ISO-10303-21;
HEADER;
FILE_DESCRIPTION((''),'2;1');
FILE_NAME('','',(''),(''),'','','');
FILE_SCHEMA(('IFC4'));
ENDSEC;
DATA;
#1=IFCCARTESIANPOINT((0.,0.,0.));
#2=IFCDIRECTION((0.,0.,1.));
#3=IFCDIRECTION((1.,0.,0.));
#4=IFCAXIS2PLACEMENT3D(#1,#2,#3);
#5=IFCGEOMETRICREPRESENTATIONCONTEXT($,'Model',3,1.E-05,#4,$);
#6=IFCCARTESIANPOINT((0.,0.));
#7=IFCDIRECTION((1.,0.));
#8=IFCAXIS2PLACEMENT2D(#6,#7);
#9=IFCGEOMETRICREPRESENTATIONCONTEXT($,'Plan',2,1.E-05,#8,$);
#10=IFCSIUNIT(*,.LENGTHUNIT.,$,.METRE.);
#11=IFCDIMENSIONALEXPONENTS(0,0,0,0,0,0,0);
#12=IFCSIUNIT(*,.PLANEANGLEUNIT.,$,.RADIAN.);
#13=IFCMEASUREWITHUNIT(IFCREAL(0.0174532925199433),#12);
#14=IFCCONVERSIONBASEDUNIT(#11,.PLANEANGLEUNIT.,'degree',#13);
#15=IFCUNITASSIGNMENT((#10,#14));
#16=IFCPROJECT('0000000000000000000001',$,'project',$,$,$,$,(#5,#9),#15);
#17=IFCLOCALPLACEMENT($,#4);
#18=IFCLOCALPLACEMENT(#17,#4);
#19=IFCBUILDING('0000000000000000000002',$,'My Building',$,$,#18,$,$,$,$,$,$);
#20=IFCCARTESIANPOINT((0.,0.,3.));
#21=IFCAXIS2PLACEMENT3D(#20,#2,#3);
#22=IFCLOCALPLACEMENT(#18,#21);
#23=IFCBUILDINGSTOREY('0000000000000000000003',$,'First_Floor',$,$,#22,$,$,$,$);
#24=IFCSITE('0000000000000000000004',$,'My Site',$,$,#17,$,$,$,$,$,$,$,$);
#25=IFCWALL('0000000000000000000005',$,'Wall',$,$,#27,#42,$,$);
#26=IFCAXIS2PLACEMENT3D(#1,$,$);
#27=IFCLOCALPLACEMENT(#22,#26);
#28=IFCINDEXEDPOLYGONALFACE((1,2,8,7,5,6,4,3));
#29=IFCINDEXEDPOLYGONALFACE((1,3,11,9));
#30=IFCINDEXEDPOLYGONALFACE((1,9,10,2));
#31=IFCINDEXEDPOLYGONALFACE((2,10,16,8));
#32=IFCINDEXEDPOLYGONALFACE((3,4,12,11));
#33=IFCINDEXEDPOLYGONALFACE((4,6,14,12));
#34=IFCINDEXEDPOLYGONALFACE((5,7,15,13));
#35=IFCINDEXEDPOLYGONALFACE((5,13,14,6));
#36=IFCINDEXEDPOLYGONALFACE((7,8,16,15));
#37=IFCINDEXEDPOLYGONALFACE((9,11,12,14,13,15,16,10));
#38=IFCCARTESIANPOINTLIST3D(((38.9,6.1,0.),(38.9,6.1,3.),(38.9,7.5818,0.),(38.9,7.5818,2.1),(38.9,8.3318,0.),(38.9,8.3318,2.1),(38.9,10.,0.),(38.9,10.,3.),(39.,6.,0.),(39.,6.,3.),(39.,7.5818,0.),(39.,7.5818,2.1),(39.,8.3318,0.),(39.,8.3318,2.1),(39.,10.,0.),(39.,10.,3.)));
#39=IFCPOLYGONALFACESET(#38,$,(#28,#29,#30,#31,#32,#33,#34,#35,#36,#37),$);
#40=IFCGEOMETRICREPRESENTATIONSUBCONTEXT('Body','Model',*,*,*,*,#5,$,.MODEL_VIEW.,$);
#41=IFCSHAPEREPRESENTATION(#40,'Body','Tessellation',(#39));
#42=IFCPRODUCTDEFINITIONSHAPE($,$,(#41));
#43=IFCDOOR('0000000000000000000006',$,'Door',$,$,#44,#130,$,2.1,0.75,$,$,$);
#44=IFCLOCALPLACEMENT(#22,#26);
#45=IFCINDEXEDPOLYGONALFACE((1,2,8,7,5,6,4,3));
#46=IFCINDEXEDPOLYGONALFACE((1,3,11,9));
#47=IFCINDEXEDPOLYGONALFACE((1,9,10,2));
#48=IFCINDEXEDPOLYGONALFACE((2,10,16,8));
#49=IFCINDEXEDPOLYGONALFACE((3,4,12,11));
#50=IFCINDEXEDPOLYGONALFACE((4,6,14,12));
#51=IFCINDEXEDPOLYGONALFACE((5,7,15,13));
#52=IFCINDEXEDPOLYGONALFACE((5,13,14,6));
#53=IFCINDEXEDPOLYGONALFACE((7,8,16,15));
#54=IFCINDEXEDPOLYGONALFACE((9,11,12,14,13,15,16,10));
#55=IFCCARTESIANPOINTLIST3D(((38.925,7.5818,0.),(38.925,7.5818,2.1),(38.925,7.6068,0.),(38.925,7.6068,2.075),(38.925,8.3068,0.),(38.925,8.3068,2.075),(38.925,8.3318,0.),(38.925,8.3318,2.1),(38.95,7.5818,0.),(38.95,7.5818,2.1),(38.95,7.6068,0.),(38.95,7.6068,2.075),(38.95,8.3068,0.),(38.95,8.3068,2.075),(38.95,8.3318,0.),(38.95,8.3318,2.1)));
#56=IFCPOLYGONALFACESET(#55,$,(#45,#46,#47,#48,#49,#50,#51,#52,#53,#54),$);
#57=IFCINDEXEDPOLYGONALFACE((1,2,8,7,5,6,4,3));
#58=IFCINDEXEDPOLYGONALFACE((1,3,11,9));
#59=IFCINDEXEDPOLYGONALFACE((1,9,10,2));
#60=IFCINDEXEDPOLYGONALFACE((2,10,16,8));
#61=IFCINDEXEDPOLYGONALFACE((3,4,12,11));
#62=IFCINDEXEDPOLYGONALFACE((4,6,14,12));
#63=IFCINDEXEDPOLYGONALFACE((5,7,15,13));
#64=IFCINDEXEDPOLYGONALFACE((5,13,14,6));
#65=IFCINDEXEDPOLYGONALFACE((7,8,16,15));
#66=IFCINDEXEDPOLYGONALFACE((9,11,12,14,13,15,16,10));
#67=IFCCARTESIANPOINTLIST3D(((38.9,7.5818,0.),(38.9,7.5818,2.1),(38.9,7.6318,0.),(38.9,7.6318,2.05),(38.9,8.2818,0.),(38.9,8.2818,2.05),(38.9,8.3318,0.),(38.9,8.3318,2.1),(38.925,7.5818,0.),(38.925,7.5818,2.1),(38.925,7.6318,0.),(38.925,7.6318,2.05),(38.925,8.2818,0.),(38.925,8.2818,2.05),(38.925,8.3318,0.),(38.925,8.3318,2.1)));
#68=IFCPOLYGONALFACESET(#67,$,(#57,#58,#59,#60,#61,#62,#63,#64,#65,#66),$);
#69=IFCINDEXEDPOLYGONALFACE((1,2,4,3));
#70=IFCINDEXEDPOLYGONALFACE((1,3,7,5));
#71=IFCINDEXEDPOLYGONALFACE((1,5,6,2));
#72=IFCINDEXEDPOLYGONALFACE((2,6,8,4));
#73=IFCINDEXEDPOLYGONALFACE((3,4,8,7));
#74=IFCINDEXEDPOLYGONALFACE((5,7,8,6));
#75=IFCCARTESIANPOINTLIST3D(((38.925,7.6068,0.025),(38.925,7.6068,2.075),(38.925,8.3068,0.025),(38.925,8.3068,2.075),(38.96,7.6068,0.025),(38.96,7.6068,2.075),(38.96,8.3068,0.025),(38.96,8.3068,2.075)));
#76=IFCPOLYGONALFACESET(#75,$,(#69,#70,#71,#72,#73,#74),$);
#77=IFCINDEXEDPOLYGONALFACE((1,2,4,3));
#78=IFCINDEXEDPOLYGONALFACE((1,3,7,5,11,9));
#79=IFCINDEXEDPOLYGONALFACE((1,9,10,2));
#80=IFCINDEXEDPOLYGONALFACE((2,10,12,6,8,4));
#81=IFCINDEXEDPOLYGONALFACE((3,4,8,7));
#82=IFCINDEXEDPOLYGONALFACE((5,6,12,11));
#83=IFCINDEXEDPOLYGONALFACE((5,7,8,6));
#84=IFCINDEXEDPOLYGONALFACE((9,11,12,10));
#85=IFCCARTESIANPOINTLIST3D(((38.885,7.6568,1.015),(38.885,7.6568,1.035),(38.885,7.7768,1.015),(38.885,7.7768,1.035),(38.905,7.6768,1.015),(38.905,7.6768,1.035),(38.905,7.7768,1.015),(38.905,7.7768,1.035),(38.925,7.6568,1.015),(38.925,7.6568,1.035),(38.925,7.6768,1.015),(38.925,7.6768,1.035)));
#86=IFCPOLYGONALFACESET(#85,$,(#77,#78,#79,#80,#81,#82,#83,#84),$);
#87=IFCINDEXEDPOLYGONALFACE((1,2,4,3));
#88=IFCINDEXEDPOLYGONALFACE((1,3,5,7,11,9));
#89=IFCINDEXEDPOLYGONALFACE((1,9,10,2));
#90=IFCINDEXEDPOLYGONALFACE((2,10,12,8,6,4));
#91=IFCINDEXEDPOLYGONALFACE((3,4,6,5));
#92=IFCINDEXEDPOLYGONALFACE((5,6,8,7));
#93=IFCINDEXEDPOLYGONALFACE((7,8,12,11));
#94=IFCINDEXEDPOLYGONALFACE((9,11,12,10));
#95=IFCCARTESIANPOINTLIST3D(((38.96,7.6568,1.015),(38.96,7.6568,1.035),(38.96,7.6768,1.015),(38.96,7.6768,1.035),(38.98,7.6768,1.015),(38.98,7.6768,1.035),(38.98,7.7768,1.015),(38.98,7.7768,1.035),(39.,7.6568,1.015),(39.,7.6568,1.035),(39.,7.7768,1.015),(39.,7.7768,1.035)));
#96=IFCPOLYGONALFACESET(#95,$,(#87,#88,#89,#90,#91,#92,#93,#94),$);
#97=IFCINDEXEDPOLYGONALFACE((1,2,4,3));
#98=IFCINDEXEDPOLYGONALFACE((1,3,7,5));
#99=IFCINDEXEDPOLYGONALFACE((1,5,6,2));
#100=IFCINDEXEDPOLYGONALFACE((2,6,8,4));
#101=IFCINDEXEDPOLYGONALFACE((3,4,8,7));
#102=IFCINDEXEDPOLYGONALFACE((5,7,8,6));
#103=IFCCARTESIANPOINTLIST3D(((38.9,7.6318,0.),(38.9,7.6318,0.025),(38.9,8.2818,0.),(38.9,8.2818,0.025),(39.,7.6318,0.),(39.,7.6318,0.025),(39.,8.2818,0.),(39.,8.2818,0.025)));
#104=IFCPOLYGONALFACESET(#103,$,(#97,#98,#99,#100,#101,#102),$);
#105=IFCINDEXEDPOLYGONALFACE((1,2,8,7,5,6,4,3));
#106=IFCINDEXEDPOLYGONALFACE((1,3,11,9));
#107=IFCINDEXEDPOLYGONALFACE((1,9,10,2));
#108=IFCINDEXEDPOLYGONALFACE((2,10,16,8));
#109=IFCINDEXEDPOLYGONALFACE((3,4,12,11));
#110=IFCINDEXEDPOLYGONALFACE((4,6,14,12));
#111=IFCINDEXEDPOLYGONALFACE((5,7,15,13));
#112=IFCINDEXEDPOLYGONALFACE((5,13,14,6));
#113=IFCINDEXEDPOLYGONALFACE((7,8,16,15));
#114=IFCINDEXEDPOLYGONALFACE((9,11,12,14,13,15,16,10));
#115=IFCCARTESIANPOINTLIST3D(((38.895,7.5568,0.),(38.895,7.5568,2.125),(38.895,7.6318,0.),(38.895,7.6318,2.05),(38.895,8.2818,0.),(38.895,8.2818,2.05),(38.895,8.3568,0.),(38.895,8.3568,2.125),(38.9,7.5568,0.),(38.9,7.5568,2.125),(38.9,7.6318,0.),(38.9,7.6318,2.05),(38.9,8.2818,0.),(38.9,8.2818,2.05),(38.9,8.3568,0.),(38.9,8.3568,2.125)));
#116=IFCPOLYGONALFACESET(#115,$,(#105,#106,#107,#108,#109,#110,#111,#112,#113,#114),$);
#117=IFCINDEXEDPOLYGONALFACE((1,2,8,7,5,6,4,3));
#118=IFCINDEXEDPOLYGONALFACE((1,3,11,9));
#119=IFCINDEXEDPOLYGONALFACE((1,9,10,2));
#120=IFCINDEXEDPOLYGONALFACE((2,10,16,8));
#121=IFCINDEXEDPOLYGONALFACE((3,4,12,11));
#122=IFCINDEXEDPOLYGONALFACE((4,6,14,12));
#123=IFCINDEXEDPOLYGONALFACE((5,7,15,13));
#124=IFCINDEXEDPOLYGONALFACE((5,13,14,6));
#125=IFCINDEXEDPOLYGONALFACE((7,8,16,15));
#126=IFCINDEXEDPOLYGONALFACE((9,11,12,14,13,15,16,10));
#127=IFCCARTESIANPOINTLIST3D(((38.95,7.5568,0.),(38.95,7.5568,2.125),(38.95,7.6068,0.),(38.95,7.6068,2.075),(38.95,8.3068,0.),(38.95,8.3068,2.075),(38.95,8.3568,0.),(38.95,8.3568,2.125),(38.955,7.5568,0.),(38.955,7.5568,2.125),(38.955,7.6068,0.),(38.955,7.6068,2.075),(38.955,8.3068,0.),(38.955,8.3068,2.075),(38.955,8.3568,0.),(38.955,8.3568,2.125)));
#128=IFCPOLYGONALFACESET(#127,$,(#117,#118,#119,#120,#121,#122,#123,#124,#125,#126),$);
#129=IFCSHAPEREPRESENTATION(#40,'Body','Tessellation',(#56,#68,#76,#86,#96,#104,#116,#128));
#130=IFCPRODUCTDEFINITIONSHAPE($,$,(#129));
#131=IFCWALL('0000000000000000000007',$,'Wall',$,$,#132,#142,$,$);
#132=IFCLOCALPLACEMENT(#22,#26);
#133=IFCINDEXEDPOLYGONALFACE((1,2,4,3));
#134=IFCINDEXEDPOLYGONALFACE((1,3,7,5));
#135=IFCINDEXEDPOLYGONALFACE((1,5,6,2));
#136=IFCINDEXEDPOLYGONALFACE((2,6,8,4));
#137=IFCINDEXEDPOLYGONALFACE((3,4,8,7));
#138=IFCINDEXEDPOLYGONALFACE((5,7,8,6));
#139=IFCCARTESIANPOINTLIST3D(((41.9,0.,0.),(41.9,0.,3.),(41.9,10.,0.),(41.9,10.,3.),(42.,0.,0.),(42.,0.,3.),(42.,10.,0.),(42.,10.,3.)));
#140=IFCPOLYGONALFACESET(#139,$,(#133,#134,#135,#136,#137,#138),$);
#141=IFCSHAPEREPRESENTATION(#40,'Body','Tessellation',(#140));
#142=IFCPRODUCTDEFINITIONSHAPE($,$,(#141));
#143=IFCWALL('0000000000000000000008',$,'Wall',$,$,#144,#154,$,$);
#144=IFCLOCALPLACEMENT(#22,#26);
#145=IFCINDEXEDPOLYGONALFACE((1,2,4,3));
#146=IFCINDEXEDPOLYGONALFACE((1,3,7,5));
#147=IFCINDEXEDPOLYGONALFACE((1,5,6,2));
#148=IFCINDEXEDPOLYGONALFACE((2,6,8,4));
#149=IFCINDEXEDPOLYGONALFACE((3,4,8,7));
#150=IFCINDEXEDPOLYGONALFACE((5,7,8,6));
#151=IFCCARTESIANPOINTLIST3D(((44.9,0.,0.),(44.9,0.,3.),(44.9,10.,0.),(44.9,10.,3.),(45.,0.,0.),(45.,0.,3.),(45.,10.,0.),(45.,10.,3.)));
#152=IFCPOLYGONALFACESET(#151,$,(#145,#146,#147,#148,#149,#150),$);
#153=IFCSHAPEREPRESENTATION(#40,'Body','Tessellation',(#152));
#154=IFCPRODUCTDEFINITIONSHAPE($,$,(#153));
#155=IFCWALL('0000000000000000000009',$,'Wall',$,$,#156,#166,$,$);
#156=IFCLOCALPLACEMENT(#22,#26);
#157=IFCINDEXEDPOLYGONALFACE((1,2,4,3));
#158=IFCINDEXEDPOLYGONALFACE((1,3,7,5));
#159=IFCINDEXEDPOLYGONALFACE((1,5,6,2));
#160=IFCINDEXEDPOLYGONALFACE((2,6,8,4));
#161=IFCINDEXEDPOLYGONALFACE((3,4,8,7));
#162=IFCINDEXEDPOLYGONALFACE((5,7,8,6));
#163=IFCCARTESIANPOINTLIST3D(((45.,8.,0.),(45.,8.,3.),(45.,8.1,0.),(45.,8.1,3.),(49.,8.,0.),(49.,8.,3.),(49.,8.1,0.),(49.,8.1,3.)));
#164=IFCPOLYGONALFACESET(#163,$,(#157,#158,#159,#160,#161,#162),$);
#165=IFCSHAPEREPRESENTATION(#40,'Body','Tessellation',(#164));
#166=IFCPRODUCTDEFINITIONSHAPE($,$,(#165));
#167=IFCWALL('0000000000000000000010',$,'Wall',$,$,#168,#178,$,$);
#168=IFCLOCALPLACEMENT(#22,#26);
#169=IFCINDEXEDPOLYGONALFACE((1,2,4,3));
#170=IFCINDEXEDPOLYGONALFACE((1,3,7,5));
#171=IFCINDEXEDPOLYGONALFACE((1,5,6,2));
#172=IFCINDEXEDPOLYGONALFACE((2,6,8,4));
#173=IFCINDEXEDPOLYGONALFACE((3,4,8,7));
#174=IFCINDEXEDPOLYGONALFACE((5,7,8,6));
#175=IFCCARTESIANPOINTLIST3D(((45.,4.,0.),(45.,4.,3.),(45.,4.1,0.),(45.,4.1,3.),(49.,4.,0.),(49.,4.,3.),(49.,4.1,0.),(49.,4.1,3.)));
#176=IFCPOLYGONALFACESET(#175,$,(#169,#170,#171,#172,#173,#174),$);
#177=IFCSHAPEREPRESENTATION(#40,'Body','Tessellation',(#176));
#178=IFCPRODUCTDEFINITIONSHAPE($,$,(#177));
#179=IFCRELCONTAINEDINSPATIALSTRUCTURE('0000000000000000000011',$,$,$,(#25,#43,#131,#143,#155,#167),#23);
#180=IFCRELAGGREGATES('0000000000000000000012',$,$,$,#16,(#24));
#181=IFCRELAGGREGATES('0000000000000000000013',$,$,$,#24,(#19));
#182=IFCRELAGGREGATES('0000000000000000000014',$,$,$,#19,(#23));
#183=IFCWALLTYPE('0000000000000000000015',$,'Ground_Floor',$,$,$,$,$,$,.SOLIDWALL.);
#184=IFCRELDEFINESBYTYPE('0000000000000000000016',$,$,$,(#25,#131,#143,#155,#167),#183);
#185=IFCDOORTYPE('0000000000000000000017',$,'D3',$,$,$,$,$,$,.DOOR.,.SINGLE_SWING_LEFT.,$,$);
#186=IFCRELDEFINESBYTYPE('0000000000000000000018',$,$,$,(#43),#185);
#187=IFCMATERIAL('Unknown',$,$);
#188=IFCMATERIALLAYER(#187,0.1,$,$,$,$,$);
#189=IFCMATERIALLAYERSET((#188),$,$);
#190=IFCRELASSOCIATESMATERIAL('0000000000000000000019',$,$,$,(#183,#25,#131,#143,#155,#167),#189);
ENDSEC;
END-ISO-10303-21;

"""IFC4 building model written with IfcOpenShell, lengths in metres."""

from ifc_helpers import new_model, entity, si_unit, converted_unit, frame, origin_with_axes, origin_2d_with_axis, place, context, subcontext, project, spatial, line, indexed_curve, outline, extrude, shape, source, transform, mapped, material, layer, layer_set, layer_usage, type_object, type_shapes, element, fill, save


model = new_model("IFC4")

# Units and contexts
model_context = context("Model", 3, precision=1e-05, world=origin_with_axes())
plan_context = context("Plan", 2, precision=1e-05, world=origin_2d_with_axis())
body_context_1 = subcontext(model_context, "Body", "Model", "MODEL_VIEW")
body_context_2 = subcontext(plan_context, "Body", "Plan", "PLAN_VIEW")
ifc_project = project(units=[si_unit("LENGTHUNIT", "METRE"), converted_unit("PLANEANGLEUNIT", "degree", entity("IfcReal", 0.0174532925199433), si_unit("PLANEANGLEUNIT", "RADIAN"), dimensions=[0, 0, 0, 0, 0, 0, 0])], contexts=[model_context, plan_context])

# Site, building, storey
site_placement = place(None, origin_with_axes())
site = spatial("IfcSite", under=ifc_project, at=site_placement, Name="My Site")
building_placement = place(site_placement, origin_with_axes())
building = spatial("IfcBuilding", under=site, at=building_placement, Name="My Building")
storey_placement = place(building_placement, frame((0.0, 0.0, 3.0), z_axis=(0.0, 0.0, 1.0), x_axis=(1.0, 0.0, 0.0)))
storey = spatial("IfcBuildingStorey", under=building, at=storey_placement, Name="First_Floor")

# Shared definitions
ifc_material = material(Name="Unknown")

# Shared definitions
ifc_layer = layer(ifc_material, 0.1)
ifc_layer_set = layer_set([ifc_layer])
wall_type = type_object("IfcWallType", Name="Ground_Floor", PredefinedType="SOLIDWALL", material=ifc_layer_set)

# Wall, opening, door
ifc_layer_usage_1 = layer_usage(ifc_layer_set, "AXIS2", "POSITIVE", 0.0)
wall_1_placement = place(storey_placement, frame((39.0, 6.0, 0.0), z_axis=(0.0, 0.0, 1.0), x_axis=(0.0, 1.0, 0.0)))
wall_1 = element("IfcWall", 1, at=wall_1_placement, inside=storey, type_object=wall_type, material=ifc_layer_usage_1, Name="Wall", context=body_context_1, shape_type="SweptSolid", body=[
    extrude(outline(indexed_curve([(0.0, 0.0), (0.1, 0.1), (4.0, 0.1), (4.0, 0.0)], segments=[line(1, 2, 3, 4, 1)])), origin_with_axes(), (0.0, 0.0, 1.0), 3.0),
])
shared_shape_1 = source(origin_with_axes(), body_context_1, "Body", "SweptSolid", [
    extrude(outline(indexed_curve([(0.0, 0.0), (0.75, 0.0), (0.75, 2.1), (0.0, 2.1)], segments=[line(1, 2, 3, 4, 1)])), frame((0.0, -0.6, 0.0), z_axis=(0.0, -1.0, 0.0), x_axis=(1.0, 0.0, 0.0)), (0.0, 0.0, -1.0), 1.2),
])
opening_1_placement = place(wall_1_placement, frame((2.3318, 0.1, 0.0), z_axis=(0.0, 0.0, 1.0), x_axis=(-1.0, 0.0, 0.0)))
opening_1 = element("IfcOpeningElement", 2, at=opening_1_placement, cuts=wall_1, PredefinedType="OPENING", context=body_context_1, shape_type="MappedRepresentation", body=[
    mapped(shared_shape_1, transform((0.0, 0.0, 0.0), x_axis=(1.0, 0.0, 0.0), y_axis=(0.0, 1.0, 0.0), z_axis=(0.0, 0.0, 1.0), scale=1.0)),
])
door_type_1 = type_object("IfcDoorType", Name="D3", OperationType="SINGLE_SWING_LEFT", PredefinedType="DOOR")
shared_shape_2 = source(origin_with_axes(), body_context_1, "Body", "SweptSolid", [
    extrude(outline(indexed_curve([(0.0, 0.0), (0.0, 2.1), (0.75, 2.1), (0.75, 0.0), (0.725, 0.0), (0.725, 2.075), (0.025, 2.075), (0.025, 0.0)], segments=[line(1, 2, 3, 4, 5, 6, 7, 8, 1)])), frame((0.0, 0.025, 0.0), z_axis=(0.0, -1.0, 0.0), x_axis=(1.0, 0.0, 0.0)), (0.0, 0.0, -1.0), 0.025),
    extrude(outline(indexed_curve([(0.0, 0.0), (0.0, 2.1), (0.75, 2.1), (0.75, 0.0), (0.7, 0.0), (0.7, 2.05), (0.05, 2.05), (0.05, 0.0)], segments=[line(1, 2, 3, 4, 5, 6, 7, 8, 1)])), frame((0.0, 0.0, 0.0), z_axis=(0.0, -1.0, 0.0), x_axis=(1.0, 0.0, 0.0)), (0.0, 0.0, -1.0), 0.025),
    extrude(outline(indexed_curve([(0.0, 0.0), (0.7, 0.0), (0.7, 0.035), (0.0, 0.035)], segments=[line(1, 2, 3, 4, 1)])), frame((0.025, 0.025, 0.025), z_axis=(0.0, 0.0, 1.0), x_axis=(1.0, 0.0, 0.0)), (0.0, 0.0, 1.0), 2.05),
    extrude(outline(indexed_curve([(0.0, 0.0), (0.0, -0.04), (-0.12, -0.04), (-0.12, -0.02), (-0.02, -0.02), (-0.02, 0.0)], segments=[line(1, 2, 3, 4, 5, 6, 1)])), frame((0.675, 0.025, 1.015), z_axis=(0.0, 0.0, 1.0), x_axis=(1.0, 0.0, 0.0)), (0.0, 0.0, 1.0), 0.02),
    extrude(outline(indexed_curve([(0.0, 0.0), (0.0, 0.04), (-0.12, 0.04), (-0.12, 0.02), (-0.02, 0.02), (-0.02, 0.0)], segments=[line(1, 2, 3, 4, 5, 6, 1)])), frame((0.675, 0.06, 1.015), z_axis=(0.0, 0.0, 1.0), x_axis=(1.0, 0.0, 0.0)), (0.0, 0.0, 1.0), 0.02),
    extrude(outline(indexed_curve([(0.0, 0.0), (0.65, 0.0), (0.65, 0.1), (0.0, 0.1)], segments=[line(1, 2, 3, 4, 1)])), frame((0.05, 0.0, 0.0), z_axis=(0.0, 0.0, 1.0), x_axis=(1.0, 0.0, 0.0)), (0.0, 0.0, 1.0), 0.025),
    extrude(outline(indexed_curve([(0.0, 0.0), (0.0, 2.125), (0.8, 2.125), (0.8, 0.0), (0.725, 0.0), (0.725, 2.05), (0.075, 2.05), (0.075, 0.0)], segments=[line(1, 2, 3, 4, 5, 6, 7, 8, 1)])), frame((-0.025, -0.005, 0.0), z_axis=(0.0, -1.0, 0.0), x_axis=(1.0, 0.0, 0.0)), (0.0, 0.0, -1.0), 0.005),
    extrude(outline(indexed_curve([(0.0, 0.0), (0.0, 2.125), (0.8, 2.125), (0.8, 0.0), (0.75, 0.0), (0.75, 2.075), (0.05, 2.075), (0.05, 0.0)], segments=[line(1, 2, 3, 4, 5, 6, 7, 8, 1)])), frame((-0.025, 0.05, 0.0), z_axis=(0.0, -1.0, 0.0), x_axis=(1.0, 0.0, 0.0)), (0.0, 0.0, -1.0), 0.005),
])
shared_shape_3 = source(origin_with_axes(), body_context_2, "Body", "Curve2D", [
    entity("IfcIndexedPolyCurve", entity("IfcCartesianPointList2D", [[0.0, 0.0], [0.0, 0.05], [0.025, 0.05], [0.025, 0.025], [0.05, 0.025], [0.05, 0.0]]), [entity("IfcLineIndex", [1, 2, 3, 4, 5, 6, 1])]),
    entity("IfcIndexedPolyCurve", entity("IfcCartesianPointList2D", [[0.75, 0.0], [0.75, 0.05], [0.725, 0.05], [0.725, 0.025], [0.7, 0.025], [0.7, 0.0]]), [entity("IfcLineIndex", [1, 2, 3, 4, 5, 6, 1])]),
    entity("IfcTrimmedCurve", entity("IfcEllipse", entity("IfcAxis2Placement2D", entity("IfcCartesianPoint", [0.06, 0.05]), entity("IfcDirection", [1.0, 0.0])), 0.665, 0.7), [entity("IfcCartesianPoint", [0.725, 0.05])], [entity("IfcCartesianPoint", [0.06, 0.75])], True, "CARTESIAN"),
    entity("IfcIndexedPolyCurve", entity("IfcCartesianPointList2D", [[0.025, 0.05], [0.06, 0.05], [0.06, 0.75], [0.025, 0.75]]), [entity("IfcLineIndex", [1, 2, 3, 4, 1])]),
])
type_shapes(door_type_1, [shared_shape_2, shared_shape_3])
door_1_placement = place(opening_1_placement, frame((0.0, 0.0, 0.0), z_axis=(0.0, 0.0, 1.0), x_axis=(1.0, 0.0, 0.0)))
door_1 = element("IfcDoor", 3, at=door_1_placement, inside=storey, type_object=door_type_1, Name="Door", OverallHeight=2.1, OverallWidth=0.75, shapes=[
    shape(body_context_1, "Body", "MappedRepresentation", [mapped(shared_shape_2, transform((0.0, 0.0, 0.0), x_axis=(1.0, 0.0, 0.0), y_axis=(0.0, 1.0, 0.0), z_axis=(0.0, 0.0, 1.0), scale=1.0))]),
    shape(body_context_2, "Body", "MappedRepresentation", [mapped(shared_shape_3, transform((0.0, 0.0, 0.0), x_axis=(1.0, 0.0, 0.0), y_axis=(0.0, 1.0, 0.0), z_axis=(0.0, 0.0, 1.0), scale=1.0))]),
])
fill(opening_1, door_1)

# Walls
ifc_layer_usage_2 = layer_usage(ifc_layer_set, "AXIS2", "POSITIVE", 0.0)
wall_2_placement = place(storey_placement, frame((41.9, 10.0, 0.0), z_axis=(0.0, 0.0, 1.0), x_axis=(0.0, -1.0, 0.0)))
element("IfcWall", 4, at=wall_2_placement, inside=storey, type_object=wall_type, material=ifc_layer_usage_2, Name="Wall", context=body_context_1, shape_type="SweptSolid", body=[
    extrude(outline(indexed_curve([(0.0, 0.0), (0.0, 0.1), (10.0, 0.1), (10.0, 0.0)], segments=[line(1, 2, 3, 4, 1)])), origin_with_axes(), (0.0, 0.0, 1.0), 3.0),
])
ifc_layer_usage_3 = layer_usage(ifc_layer_set, "AXIS2", "POSITIVE", 0.0)
wall_3_placement = place(storey_placement, frame((44.9, 10.0, 0.0), z_axis=(0.0, 0.0, 1.0), x_axis=(0.0, -1.0, 0.0)))
element("IfcWall", 5, at=wall_3_placement, inside=storey, type_object=wall_type, material=ifc_layer_usage_3, Name="Wall", context=body_context_1, shape_type="SweptSolid", body=[
    extrude(outline(indexed_curve([(0.0, 0.0), (0.0, 0.1), (10.0, 0.1), (10.0, 0.0)], segments=[line(1, 2, 3, 4, 1)])), origin_with_axes(), (0.0, 0.0, 1.0), 3.0),
])
ifc_layer_usage_4 = layer_usage(ifc_layer_set, "AXIS2", "POSITIVE", 0.0)
wall_4_placement = place(storey_placement, frame((45.0, 8.0, 0.0), z_axis=(0.0, 0.0, 1.0), x_axis=(1.0, 0.0, 0.0)))
element("IfcWall", 6, at=wall_4_placement, inside=storey, type_object=wall_type, material=ifc_layer_usage_4, Name="Wall", context=body_context_1, shape_type="SweptSolid", body=[
    extrude(outline(indexed_curve([(0.0, 0.0), (0.0, 0.1), (4.0, 0.1), (4.0, 0.0)], segments=[line(1, 2, 3, 4, 1)])), origin_with_axes(), (0.0, 0.0, 1.0), 3.0),
])
ifc_layer_usage_5 = layer_usage(ifc_layer_set, "AXIS2", "POSITIVE", 0.0)
wall_5_placement = place(storey_placement, frame((45.0, 4.0, 0.0), z_axis=(0.0, 0.0, 1.0), x_axis=(1.0, 0.0, 0.0)))
element("IfcWall", 7, at=wall_5_placement, inside=storey, type_object=wall_type, material=ifc_layer_usage_5, Name="Wall", context=body_context_1, shape_type="SweptSolid", body=[
    extrude(outline(indexed_curve([(0.0, 0.0), (0.0, 0.1), (4.0, 0.1), (4.0, 0.0)], segments=[line(1, 2, 3, 4, 1)])), origin_with_axes(), (0.0, 0.0, 1.0), 3.0),
])

save(model, "model.ifc")
